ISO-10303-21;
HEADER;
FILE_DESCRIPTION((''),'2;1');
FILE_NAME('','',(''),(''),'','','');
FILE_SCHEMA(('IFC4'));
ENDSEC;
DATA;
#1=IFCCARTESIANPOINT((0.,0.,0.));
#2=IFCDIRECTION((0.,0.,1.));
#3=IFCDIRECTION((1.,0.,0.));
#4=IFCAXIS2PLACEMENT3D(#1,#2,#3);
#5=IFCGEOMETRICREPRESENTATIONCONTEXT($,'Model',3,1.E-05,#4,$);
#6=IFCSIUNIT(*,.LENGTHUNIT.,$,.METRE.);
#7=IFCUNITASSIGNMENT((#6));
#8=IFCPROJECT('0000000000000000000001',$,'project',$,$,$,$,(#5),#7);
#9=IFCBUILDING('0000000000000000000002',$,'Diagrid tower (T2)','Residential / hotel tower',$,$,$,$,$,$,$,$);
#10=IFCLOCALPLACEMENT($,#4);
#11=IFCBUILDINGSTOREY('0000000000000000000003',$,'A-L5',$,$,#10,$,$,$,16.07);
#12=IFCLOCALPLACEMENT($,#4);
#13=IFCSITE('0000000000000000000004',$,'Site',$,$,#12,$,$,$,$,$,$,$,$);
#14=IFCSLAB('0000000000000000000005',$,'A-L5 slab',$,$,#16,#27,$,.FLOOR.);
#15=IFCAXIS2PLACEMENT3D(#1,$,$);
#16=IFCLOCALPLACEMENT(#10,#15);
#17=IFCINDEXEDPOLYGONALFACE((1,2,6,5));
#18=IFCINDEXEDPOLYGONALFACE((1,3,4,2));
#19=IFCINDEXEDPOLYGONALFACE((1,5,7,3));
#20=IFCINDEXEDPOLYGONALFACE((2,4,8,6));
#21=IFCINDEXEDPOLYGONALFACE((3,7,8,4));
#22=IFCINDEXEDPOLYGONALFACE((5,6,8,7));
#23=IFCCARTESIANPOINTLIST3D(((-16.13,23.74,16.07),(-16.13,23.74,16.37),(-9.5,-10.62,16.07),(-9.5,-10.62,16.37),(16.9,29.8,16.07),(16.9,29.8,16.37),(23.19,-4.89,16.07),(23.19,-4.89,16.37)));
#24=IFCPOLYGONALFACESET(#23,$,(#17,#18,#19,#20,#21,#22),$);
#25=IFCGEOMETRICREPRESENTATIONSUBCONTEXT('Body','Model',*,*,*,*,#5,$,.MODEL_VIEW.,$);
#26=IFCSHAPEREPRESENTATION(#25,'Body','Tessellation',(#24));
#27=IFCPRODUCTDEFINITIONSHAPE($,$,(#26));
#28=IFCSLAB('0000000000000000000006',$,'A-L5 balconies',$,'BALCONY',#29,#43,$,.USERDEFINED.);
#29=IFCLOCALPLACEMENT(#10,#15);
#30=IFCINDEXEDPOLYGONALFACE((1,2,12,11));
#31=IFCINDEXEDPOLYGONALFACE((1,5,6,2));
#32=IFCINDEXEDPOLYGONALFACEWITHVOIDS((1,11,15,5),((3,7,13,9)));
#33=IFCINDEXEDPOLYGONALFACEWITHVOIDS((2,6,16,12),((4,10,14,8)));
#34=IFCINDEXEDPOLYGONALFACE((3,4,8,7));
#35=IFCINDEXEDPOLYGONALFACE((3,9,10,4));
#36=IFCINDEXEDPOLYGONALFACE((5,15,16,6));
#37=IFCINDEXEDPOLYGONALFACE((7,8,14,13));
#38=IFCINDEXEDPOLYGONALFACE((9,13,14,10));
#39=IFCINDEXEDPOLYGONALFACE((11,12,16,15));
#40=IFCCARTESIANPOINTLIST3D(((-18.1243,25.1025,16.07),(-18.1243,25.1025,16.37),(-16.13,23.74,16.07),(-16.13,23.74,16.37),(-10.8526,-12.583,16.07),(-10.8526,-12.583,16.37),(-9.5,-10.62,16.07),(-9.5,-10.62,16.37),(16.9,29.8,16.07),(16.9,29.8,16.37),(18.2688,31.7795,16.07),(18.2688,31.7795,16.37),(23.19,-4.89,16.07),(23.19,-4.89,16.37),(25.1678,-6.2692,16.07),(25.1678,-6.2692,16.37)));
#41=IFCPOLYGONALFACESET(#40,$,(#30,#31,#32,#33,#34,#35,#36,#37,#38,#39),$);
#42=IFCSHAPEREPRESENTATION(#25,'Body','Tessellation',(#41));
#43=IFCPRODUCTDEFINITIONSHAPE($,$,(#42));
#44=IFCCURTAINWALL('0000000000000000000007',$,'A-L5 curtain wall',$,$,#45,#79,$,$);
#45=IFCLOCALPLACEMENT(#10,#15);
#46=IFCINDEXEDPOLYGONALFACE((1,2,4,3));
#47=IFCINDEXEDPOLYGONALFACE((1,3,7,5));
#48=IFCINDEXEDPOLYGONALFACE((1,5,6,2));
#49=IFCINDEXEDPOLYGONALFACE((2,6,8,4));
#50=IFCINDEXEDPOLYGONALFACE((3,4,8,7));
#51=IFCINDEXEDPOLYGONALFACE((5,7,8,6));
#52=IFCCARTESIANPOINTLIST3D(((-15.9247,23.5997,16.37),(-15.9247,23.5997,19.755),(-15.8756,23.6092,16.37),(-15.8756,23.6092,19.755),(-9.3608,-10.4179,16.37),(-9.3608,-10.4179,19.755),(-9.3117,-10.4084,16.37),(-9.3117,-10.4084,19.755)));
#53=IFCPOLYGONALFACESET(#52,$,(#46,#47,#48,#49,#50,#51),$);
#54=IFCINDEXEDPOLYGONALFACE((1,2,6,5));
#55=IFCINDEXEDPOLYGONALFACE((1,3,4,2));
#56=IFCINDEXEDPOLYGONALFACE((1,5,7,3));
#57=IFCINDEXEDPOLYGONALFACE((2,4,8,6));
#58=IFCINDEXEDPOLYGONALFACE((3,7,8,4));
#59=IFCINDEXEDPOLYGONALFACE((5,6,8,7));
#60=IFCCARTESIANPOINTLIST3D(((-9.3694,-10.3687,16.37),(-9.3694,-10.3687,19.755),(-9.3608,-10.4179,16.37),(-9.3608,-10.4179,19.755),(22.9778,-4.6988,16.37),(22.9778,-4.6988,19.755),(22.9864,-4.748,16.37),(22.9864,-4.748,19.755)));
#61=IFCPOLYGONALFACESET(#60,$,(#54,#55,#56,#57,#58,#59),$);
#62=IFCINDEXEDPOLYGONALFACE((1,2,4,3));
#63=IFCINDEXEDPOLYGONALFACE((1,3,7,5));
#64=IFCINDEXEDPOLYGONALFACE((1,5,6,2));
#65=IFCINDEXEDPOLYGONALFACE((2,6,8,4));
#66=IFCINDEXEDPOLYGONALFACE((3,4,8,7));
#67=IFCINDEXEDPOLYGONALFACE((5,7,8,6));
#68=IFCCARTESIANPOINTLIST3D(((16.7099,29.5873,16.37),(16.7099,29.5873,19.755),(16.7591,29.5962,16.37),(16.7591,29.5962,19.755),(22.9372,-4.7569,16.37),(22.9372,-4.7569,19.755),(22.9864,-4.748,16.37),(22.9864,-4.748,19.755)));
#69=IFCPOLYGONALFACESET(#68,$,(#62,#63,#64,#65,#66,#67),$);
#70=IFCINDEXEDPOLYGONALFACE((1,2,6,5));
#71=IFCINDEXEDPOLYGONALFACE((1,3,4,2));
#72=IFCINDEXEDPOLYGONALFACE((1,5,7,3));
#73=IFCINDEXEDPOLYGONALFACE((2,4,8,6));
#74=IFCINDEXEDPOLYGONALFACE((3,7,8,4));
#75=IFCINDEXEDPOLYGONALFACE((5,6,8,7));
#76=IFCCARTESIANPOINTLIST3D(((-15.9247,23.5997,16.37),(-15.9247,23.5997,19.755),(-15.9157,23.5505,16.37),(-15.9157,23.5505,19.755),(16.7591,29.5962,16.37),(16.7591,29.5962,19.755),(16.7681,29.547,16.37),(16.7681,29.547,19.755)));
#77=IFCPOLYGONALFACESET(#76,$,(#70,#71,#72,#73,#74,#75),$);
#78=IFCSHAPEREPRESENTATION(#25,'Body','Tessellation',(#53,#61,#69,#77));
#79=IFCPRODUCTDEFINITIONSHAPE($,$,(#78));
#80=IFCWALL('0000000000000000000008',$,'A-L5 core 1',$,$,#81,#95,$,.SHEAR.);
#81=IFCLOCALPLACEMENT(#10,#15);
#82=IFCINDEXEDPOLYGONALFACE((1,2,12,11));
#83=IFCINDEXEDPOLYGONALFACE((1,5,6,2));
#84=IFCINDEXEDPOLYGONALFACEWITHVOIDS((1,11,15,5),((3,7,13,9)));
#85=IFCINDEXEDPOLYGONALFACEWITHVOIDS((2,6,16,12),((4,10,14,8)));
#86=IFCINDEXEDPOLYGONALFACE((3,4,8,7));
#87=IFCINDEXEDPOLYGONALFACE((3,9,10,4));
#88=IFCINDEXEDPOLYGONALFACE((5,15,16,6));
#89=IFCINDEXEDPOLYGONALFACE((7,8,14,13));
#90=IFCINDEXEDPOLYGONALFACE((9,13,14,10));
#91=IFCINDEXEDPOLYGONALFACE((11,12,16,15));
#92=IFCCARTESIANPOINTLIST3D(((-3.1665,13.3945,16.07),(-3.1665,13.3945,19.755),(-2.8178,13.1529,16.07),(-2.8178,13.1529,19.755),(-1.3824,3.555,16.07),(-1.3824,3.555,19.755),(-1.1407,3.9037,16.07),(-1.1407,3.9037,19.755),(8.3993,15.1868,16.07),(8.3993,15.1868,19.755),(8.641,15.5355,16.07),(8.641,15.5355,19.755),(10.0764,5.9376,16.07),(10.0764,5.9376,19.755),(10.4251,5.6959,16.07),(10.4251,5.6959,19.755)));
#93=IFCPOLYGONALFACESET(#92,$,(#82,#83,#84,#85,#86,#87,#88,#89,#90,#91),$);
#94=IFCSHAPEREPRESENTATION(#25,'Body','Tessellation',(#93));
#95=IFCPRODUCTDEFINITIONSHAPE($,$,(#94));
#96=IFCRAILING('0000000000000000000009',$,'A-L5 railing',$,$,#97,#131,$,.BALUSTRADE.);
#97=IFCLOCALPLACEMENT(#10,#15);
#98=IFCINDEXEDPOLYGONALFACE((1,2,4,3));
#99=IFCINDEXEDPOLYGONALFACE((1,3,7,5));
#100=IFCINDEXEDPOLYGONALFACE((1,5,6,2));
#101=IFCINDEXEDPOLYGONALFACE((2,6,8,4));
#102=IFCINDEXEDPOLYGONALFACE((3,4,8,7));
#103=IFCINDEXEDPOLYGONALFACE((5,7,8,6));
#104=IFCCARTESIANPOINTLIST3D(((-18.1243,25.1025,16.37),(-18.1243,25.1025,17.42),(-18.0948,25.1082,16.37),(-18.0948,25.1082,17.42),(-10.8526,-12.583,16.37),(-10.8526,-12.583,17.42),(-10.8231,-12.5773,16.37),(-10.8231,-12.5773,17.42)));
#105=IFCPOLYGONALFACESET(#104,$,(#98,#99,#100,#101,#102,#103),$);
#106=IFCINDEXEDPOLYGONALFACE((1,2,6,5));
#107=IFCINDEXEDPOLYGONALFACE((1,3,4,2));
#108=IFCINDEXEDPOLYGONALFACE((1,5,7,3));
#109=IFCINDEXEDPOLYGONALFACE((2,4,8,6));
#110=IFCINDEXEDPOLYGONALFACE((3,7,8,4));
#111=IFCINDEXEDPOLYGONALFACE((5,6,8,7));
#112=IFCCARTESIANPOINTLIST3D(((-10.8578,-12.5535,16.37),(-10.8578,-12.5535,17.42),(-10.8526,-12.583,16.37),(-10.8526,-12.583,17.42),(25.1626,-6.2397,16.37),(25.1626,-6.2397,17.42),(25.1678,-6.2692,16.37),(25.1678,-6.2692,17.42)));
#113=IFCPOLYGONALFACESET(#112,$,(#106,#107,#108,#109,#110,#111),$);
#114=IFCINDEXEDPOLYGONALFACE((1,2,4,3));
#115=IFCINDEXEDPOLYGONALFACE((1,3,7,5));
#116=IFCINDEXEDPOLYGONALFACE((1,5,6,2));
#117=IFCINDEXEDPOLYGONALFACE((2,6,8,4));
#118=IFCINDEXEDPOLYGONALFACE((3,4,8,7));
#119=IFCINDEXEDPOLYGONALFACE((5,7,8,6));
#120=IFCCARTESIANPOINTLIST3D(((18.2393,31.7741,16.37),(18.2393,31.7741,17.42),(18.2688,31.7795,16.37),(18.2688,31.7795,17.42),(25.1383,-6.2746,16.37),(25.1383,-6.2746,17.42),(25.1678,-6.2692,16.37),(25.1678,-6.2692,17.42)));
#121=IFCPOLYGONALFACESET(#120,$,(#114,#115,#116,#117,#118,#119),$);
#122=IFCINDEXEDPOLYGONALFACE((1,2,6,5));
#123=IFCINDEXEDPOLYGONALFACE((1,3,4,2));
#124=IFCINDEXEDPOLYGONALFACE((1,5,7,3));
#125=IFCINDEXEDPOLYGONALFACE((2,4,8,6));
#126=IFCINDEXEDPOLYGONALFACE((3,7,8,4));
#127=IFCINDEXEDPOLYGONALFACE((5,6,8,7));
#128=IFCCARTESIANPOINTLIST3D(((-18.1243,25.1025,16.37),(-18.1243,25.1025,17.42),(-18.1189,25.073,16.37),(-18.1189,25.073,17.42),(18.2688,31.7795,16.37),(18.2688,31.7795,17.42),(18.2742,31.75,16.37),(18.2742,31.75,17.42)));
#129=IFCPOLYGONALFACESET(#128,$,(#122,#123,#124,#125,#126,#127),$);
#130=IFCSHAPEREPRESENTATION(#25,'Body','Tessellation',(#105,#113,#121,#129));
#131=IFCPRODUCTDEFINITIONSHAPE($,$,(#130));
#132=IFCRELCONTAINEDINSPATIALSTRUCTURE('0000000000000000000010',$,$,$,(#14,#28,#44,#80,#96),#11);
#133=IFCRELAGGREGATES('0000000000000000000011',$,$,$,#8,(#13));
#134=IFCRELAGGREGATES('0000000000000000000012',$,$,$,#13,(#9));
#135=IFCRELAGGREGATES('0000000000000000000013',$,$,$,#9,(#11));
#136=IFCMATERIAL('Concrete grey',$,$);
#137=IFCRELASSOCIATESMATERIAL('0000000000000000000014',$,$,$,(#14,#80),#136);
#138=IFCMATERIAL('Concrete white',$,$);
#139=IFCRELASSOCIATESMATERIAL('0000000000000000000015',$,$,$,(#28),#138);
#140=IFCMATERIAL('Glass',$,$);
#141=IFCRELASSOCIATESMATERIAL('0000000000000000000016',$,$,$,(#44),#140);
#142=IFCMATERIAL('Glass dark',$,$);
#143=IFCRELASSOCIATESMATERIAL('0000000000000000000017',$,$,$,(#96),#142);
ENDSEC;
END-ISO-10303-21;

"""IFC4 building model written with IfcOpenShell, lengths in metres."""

from ifc_helpers import new_model, si_unit, frame, origin_with_axes, place, context, subcontext, project, spatial, polyline, outline, extrude, material, element, save


model = new_model("IFC4")

# Units and contexts
model_context = context("Model", 3, precision=1e-05, world=origin_with_axes())
body_context = subcontext(model_context, "Body", "Model", "MODEL_VIEW")
ifc_project = project(units=[si_unit("LENGTHUNIT", "METRE")], contexts=[model_context])

# Site, building, storey
site_placement = place(None, origin_with_axes())
site = spatial("IfcSite", under=ifc_project, at=site_placement, Name="Site")
building = spatial("IfcBuilding", under=site, Name="Diagrid tower (T2)", Description="Residential / hotel tower")
storey_placement = place(None, origin_with_axes())
storey = spatial("IfcBuildingStorey", under=building, at=storey_placement, Name="A-L5", Elevation=16.07)

# Slabs
ifc_material_1 = material(Name="Concrete grey")
slab_1_placement = place(storey_placement, origin_with_axes())
element("IfcSlab", 1, at=slab_1_placement, inside=storey, material=ifc_material_1, Name="A-L5 slab", PredefinedType="FLOOR", context=body_context, shape_type="SweptSolid", body=[
    extrude(outline(polyline([(-16.13, 23.74), (-9.5, -10.62), (23.19, -4.89), (16.9, 29.8), (-16.13, 23.74)])), frame((0.0, 0.0, 16.07), z_axis=(0.0, 0.0, 1.0), x_axis=(1.0, 0.0, 0.0)), (0.0, 0.0, 1.0), 0.3),
])
ifc_material_2 = material(Name="Concrete white")
slab_2_placement = place(storey_placement, origin_with_axes())
element("IfcSlab", 2, at=slab_2_placement, inside=storey, material=ifc_material_2, Name="A-L5 balconies", ObjectType="BALCONY", PredefinedType="USERDEFINED", context=body_context, shape_type="SweptSolid", body=[
    extrude(outline(polyline([(-18.1243, 25.1025), (-10.8526, -12.583), (25.1678, -6.2692), (18.2688, 31.7795), (-18.1243, 25.1025)]), holes=[polyline([(-16.13, 23.74), (-9.5, -10.62), (23.19, -4.89), (16.9, 29.8), (-16.13, 23.74)])]), frame((0.0, 0.0, 16.07), z_axis=(0.0, 0.0, 1.0), x_axis=(1.0, 0.0, 0.0)), (0.0, 0.0, 1.0), 0.3),
])

# Curtain wall
ifc_material_3 = material(Name="Glass")
curtain_wall_placement = place(storey_placement, origin_with_axes())
element("IfcCurtainWall", 3, at=curtain_wall_placement, inside=storey, material=ifc_material_3, Name="A-L5 curtain wall", context=body_context, shape_type="SweptSolid", body=[
    extrude(outline(polyline([(-15.9247, 23.5997), (-9.3608, -10.4179), (-9.3117, -10.4084), (-15.8756, 23.6092), (-15.9247, 23.5997)])), frame((0.0, 0.0, 16.37), z_axis=(0.0, 0.0, 1.0), x_axis=(1.0, 0.0, 0.0)), (0.0, 0.0, 1.0), 3.385),
    extrude(outline(polyline([(-9.3608, -10.4179), (22.9864, -4.748), (22.9778, -4.6988), (-9.3694, -10.3687), (-9.3608, -10.4179)])), frame((0.0, 0.0, 16.37), z_axis=(0.0, 0.0, 1.0), x_axis=(1.0, 0.0, 0.0)), (0.0, 0.0, 1.0), 3.385),
    extrude(outline(polyline([(22.9864, -4.748), (16.7591, 29.5962), (16.7099, 29.5873), (22.9372, -4.7569), (22.9864, -4.748)])), frame((0.0, 0.0, 16.37), z_axis=(0.0, 0.0, 1.0), x_axis=(1.0, 0.0, 0.0)), (0.0, 0.0, 1.0), 3.385),
    extrude(outline(polyline([(16.7591, 29.5962), (-15.9247, 23.5997), (-15.9157, 23.5505), (16.7681, 29.547), (16.7591, 29.5962)])), frame((0.0, 0.0, 16.37), z_axis=(0.0, 0.0, 1.0), x_axis=(1.0, 0.0, 0.0)), (0.0, 0.0, 1.0), 3.385),
])

# Wall
wall_placement = place(storey_placement, origin_with_axes())
element("IfcWall", 4, at=wall_placement, inside=storey, material=ifc_material_1, Name="A-L5 core 1", PredefinedType="SHEAR", context=body_context, shape_type="SweptSolid", body=[
    extrude(outline(polyline([(10.4251, 5.6959), (8.641, 15.5355), (-3.1665, 13.3945), (-1.3824, 3.555), (10.4251, 5.6959)]), holes=[polyline([(10.0764, 5.9376), (8.3993, 15.1868), (-2.8178, 13.1529), (-1.1407, 3.9037), (10.0764, 5.9376)])]), frame((0.0, 0.0, 16.07), z_axis=(0.0, 0.0, 1.0), x_axis=(1.0, 0.0, 0.0)), (0.0, 0.0, 1.0), 3.685),
])

# Railing
ifc_material_4 = material(Name="Glass dark")
railing_placement = place(storey_placement, origin_with_axes())
element("IfcRailing", 5, at=railing_placement, inside=storey, material=ifc_material_4, Name="A-L5 railing", PredefinedType="BALUSTRADE", context=body_context, shape_type="SweptSolid", body=[
    extrude(outline(polyline([(-18.1243, 25.1025), (-10.8526, -12.583), (-10.8231, -12.5773), (-18.0948, 25.1082), (-18.1243, 25.1025)])), frame((0.0, 0.0, 16.37), z_axis=(0.0, 0.0, 1.0), x_axis=(1.0, 0.0, 0.0)), (0.0, 0.0, 1.0), 1.05),
    extrude(outline(polyline([(-10.8526, -12.583), (25.1678, -6.2692), (25.1626, -6.2397), (-10.8578, -12.5535), (-10.8526, -12.583)])), frame((0.0, 0.0, 16.37), z_axis=(0.0, 0.0, 1.0), x_axis=(1.0, 0.0, 0.0)), (0.0, 0.0, 1.0), 1.05),
    extrude(outline(polyline([(25.1678, -6.2692), (18.2688, 31.7795), (18.2393, 31.7741), (25.1383, -6.2746), (25.1678, -6.2692)])), frame((0.0, 0.0, 16.37), z_axis=(0.0, 0.0, 1.0), x_axis=(1.0, 0.0, 0.0)), (0.0, 0.0, 1.0), 1.05),
    extrude(outline(polyline([(18.2688, 31.7795), (-18.1243, 25.1025), (-18.1189, 25.073), (18.2742, 31.75), (18.2688, 31.7795)])), frame((0.0, 0.0, 16.37), z_axis=(0.0, 0.0, 1.0), x_axis=(1.0, 0.0, 0.0)), (0.0, 0.0, 1.0), 1.05),
])

save(model, "model.ifc")
